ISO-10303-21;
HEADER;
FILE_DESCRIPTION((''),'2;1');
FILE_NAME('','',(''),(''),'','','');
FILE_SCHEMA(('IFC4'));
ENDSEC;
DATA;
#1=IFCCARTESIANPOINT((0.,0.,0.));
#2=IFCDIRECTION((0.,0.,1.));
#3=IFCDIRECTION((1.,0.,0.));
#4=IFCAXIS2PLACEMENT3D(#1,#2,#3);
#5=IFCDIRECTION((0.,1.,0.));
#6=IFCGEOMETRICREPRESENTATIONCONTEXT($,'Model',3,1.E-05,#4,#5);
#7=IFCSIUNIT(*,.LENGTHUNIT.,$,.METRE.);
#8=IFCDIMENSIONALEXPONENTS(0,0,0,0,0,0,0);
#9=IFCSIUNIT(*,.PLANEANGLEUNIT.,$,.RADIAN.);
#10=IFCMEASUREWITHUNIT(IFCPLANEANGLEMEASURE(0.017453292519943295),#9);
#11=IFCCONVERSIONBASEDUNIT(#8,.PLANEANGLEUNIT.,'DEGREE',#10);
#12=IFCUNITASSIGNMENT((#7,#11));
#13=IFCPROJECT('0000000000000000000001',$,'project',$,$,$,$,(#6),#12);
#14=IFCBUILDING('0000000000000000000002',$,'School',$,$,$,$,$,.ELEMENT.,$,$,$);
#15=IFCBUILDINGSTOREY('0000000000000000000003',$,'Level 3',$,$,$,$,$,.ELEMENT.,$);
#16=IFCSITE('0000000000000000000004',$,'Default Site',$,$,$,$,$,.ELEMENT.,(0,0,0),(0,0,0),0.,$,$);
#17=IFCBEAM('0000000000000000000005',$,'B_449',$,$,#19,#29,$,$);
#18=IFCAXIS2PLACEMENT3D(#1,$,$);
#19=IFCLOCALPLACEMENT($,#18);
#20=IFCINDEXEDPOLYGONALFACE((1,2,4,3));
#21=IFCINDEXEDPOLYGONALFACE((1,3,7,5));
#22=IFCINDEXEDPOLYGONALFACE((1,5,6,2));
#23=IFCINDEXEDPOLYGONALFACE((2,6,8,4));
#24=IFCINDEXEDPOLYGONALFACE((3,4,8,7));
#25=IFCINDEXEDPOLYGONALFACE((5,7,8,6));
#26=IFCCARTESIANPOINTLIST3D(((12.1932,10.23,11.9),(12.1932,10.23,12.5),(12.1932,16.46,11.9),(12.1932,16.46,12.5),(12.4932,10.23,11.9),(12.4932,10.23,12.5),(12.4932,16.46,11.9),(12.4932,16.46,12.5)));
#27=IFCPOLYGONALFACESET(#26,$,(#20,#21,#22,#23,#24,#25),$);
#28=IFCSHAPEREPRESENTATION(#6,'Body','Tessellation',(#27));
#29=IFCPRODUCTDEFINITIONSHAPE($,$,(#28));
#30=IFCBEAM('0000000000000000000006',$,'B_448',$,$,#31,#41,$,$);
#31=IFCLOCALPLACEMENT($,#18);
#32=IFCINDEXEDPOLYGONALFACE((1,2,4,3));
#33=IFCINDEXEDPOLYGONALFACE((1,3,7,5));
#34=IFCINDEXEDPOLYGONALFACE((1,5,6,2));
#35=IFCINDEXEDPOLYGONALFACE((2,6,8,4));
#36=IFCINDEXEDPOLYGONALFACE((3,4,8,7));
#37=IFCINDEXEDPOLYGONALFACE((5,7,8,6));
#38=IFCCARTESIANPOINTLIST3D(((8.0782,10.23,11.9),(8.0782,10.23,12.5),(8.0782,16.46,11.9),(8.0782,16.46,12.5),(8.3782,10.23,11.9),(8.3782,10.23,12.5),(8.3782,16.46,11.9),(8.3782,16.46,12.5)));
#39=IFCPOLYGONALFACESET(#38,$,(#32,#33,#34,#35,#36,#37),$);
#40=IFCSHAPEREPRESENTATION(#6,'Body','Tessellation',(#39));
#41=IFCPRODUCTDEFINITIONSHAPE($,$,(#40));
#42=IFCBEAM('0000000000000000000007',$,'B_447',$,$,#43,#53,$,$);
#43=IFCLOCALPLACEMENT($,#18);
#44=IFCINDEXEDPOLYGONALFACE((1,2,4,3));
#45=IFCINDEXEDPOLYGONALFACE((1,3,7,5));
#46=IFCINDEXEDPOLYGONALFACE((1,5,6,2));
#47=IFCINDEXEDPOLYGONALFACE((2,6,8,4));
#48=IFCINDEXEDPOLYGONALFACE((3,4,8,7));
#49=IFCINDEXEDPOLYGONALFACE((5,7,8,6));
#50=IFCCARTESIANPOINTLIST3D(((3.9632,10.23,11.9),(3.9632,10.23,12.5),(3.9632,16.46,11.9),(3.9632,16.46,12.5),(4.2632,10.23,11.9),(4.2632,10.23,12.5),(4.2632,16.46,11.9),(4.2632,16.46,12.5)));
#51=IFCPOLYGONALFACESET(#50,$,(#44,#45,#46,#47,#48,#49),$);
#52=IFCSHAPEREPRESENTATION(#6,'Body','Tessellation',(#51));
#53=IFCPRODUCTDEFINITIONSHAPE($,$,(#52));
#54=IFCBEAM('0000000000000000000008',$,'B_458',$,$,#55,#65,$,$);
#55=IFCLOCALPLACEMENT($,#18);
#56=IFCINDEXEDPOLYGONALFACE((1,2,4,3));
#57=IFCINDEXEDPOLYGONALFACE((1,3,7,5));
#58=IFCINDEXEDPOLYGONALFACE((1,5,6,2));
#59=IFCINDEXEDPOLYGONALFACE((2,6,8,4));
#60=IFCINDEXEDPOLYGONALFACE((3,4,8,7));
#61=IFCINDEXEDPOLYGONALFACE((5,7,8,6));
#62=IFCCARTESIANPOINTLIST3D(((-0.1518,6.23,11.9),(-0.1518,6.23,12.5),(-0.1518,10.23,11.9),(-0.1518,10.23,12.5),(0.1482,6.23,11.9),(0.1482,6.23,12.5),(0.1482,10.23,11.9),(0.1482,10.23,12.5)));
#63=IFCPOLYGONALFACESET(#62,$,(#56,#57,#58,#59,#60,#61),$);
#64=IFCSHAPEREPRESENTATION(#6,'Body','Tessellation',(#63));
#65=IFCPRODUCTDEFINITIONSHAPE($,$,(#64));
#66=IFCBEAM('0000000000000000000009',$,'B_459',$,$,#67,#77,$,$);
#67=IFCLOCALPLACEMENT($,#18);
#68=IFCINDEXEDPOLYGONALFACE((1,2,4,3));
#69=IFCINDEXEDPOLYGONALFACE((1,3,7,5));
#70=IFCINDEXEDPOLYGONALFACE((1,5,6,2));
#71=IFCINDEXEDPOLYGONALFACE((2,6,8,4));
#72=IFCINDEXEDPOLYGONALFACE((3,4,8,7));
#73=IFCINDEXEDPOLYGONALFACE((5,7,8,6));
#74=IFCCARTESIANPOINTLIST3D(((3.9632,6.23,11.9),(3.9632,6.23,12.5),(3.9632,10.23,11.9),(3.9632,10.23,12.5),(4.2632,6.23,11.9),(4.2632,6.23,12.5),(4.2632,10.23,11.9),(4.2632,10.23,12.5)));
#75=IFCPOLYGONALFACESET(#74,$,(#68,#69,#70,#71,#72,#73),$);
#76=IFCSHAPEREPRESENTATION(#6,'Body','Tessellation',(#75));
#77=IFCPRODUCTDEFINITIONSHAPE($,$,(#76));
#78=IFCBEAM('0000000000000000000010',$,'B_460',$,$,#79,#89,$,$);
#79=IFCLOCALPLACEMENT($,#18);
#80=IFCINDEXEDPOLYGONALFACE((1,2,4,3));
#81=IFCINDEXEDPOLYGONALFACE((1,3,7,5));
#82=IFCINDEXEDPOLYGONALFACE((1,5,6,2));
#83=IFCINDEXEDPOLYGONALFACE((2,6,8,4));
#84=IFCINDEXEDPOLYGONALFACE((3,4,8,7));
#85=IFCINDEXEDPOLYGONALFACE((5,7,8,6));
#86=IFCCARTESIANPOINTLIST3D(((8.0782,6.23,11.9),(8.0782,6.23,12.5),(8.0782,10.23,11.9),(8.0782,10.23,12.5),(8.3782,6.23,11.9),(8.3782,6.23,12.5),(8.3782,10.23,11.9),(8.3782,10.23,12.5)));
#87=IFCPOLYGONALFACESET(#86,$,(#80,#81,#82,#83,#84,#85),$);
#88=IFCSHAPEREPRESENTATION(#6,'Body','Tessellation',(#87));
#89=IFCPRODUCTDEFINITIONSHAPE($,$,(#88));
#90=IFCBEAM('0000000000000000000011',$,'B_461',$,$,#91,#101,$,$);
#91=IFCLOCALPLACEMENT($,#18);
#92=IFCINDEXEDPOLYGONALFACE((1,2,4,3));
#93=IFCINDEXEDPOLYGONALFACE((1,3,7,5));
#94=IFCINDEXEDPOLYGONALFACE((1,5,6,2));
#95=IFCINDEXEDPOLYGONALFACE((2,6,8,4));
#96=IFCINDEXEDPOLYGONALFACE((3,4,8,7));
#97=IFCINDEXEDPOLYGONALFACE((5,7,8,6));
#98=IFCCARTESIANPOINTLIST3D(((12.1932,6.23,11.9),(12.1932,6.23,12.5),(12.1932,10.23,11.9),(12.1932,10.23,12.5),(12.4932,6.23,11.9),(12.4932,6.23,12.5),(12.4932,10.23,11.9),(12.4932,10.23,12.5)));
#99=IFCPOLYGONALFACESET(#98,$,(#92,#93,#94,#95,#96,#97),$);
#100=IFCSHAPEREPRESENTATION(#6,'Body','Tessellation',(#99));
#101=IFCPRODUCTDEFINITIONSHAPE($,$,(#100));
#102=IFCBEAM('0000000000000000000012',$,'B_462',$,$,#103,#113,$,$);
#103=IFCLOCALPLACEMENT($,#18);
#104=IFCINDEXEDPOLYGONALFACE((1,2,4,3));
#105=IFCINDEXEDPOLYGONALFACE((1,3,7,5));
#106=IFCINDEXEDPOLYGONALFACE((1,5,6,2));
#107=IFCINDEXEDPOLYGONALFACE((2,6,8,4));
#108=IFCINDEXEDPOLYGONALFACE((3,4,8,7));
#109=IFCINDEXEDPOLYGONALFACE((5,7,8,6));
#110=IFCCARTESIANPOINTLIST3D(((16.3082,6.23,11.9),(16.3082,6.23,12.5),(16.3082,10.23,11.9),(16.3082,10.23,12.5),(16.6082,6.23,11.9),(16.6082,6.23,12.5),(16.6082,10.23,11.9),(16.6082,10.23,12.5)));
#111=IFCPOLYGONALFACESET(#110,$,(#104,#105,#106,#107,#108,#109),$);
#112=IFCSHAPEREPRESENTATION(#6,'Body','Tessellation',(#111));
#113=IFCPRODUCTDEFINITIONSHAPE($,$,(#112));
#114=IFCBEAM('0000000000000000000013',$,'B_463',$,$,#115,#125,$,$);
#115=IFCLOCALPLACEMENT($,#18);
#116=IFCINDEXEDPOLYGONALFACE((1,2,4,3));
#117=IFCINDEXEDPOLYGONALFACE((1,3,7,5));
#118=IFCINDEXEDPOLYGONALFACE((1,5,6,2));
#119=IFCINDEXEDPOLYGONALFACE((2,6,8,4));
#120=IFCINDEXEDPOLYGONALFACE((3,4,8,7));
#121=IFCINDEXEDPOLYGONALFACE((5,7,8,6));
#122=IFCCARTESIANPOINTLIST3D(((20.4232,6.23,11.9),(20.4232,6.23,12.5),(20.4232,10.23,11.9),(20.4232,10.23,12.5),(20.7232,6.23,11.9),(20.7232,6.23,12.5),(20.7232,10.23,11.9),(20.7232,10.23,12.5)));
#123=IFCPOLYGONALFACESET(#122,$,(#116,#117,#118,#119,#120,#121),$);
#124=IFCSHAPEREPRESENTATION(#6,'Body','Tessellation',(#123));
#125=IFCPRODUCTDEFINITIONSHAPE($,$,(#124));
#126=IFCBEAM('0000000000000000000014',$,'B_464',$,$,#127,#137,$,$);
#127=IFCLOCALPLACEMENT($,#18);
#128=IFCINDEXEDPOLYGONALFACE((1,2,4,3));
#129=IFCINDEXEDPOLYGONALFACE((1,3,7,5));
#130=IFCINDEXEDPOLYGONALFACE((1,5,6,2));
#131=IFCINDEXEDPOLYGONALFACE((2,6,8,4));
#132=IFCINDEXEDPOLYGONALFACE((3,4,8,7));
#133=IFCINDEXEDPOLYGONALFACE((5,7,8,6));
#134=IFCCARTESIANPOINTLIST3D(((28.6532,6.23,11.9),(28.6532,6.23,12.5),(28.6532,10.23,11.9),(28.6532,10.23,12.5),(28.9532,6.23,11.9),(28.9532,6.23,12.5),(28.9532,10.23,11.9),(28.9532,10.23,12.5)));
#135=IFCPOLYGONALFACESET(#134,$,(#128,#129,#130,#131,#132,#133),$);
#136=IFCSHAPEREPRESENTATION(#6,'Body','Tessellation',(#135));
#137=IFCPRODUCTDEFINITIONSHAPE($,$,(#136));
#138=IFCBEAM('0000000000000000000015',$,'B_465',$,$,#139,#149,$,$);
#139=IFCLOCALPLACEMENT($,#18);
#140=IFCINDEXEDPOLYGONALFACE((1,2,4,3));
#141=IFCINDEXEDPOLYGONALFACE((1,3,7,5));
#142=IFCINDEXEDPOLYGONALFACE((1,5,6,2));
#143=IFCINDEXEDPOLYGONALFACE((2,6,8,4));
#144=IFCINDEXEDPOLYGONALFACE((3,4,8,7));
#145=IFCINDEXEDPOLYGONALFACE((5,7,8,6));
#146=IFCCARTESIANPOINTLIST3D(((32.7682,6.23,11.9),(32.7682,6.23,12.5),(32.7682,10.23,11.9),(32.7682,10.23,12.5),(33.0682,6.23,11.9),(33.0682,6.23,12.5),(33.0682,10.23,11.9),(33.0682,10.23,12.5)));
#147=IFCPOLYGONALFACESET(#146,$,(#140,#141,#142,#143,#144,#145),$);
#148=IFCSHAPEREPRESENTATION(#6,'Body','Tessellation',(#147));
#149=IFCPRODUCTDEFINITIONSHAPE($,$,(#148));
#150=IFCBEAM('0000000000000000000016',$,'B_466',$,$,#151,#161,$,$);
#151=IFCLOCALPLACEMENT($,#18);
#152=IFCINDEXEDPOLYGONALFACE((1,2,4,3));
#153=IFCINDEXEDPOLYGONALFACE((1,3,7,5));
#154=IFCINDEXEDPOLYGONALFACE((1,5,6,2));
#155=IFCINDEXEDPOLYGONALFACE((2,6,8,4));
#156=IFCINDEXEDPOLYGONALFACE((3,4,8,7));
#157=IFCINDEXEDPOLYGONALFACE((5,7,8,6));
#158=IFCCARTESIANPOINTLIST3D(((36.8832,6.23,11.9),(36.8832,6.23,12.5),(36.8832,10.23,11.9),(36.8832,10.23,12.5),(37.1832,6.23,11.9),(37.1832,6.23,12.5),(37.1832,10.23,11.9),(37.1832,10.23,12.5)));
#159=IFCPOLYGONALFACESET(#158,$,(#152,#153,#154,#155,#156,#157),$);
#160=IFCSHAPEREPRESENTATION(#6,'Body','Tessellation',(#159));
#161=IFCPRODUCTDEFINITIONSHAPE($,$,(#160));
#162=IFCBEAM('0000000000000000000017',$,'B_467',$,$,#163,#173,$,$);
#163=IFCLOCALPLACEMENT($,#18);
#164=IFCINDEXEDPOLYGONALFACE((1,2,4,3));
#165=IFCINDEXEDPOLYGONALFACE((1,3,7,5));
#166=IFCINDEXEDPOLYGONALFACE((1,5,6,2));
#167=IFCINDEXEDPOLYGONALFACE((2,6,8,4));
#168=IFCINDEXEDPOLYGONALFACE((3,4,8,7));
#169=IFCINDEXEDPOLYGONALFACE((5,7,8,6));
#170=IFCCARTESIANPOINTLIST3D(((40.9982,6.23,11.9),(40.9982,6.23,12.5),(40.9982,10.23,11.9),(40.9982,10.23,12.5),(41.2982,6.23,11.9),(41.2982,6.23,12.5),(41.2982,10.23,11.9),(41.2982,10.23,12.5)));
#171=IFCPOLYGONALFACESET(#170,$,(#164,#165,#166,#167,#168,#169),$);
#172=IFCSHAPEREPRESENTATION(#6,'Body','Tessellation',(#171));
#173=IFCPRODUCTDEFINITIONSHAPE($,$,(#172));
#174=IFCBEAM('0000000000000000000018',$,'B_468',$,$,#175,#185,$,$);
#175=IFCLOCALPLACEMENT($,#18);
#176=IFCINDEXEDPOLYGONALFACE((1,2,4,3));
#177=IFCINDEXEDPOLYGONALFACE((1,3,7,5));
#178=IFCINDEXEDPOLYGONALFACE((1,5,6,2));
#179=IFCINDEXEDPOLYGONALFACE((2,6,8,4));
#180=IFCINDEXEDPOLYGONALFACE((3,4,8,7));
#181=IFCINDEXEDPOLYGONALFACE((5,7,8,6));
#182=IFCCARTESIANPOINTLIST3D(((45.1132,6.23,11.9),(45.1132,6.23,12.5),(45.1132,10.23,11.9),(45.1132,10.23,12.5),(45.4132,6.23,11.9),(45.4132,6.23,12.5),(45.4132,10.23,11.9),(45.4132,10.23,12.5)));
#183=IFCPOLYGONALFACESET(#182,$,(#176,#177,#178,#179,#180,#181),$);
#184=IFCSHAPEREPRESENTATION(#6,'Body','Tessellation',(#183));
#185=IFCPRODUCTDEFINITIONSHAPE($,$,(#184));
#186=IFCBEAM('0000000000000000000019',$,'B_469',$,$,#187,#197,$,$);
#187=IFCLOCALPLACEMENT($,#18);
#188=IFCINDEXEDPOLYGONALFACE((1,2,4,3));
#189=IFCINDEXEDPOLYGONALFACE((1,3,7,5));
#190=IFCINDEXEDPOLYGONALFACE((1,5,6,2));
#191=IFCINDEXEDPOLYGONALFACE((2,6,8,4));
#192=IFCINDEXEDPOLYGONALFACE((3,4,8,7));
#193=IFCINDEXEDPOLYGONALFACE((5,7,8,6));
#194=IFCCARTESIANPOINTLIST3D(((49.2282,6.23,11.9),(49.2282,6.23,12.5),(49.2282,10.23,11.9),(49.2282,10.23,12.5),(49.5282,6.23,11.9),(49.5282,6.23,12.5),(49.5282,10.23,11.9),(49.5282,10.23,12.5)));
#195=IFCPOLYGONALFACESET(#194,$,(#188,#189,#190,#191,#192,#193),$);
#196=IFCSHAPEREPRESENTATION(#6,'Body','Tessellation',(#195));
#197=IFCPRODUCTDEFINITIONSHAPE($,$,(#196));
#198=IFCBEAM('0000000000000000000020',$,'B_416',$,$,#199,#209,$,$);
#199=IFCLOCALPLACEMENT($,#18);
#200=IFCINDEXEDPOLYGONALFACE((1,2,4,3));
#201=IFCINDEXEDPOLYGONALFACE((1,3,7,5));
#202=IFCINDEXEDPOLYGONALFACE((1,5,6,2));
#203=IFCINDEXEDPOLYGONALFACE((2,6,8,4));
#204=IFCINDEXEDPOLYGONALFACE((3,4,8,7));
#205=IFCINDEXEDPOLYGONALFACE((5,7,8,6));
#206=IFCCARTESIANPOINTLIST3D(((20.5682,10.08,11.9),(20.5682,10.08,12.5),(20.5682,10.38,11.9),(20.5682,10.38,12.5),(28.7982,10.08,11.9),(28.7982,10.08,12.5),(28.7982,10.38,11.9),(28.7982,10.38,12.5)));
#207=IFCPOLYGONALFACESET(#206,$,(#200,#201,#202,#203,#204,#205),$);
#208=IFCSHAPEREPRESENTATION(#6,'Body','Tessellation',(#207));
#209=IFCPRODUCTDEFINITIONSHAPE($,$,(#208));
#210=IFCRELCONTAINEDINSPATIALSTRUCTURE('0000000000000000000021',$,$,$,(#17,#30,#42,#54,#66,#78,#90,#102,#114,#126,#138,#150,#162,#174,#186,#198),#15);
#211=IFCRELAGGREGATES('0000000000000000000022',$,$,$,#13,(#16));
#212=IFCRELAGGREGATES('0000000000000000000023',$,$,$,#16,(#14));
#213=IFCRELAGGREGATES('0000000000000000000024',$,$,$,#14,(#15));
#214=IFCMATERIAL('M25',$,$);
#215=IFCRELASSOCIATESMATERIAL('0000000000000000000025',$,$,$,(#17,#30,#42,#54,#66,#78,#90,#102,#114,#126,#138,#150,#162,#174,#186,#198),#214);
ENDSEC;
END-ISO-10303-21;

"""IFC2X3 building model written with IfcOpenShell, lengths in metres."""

from ifc_helpers import new_model, entity, si_unit, converted_unit, direction, frame, frame_2d, origin_with_axes, place, context, project, spatial, rectangle, extrude, material, element, save


model = new_model("IFC2X3")

# Units and contexts
model_context = context("Model", 3, precision=1e-05, world=origin_with_axes(), true_north=direction((0.0, 1.0, 0.0)))
ifc_project = project(units=[si_unit("LENGTHUNIT", "METRE"), converted_unit("PLANEANGLEUNIT", "DEGREE", entity("IfcPlaneAngleMeasure", 0.017453292519943295), si_unit("PLANEANGLEUNIT", "RADIAN"), dimensions=[0, 0, 0, 0, 0, 0, 0])], contexts=[model_context])

# Site, building, storey
site = spatial("IfcSite", under=ifc_project, Name="Default Site", CompositionType="ELEMENT", RefLatitude=(0, 0, 0), RefLongitude=(0, 0, 0), RefElevation=0.0)
building = spatial("IfcBuilding", under=site, Name="School", CompositionType="ELEMENT")
storey = spatial("IfcBuildingStorey", under=building, Name="Level 3", CompositionType="ELEMENT")

# Shared definitions
ifc_material = material(Name="M25")
placement = place(None, origin_with_axes())

# Beams
element("IfcBeam", 1, at=placement, inside=storey, material=ifc_material, Name="B_449", context=model_context, shape_type="SweptSolid", body=[
    extrude(rectangle(XDim=0.3, YDim=0.6, at=frame_2d((0.0, 0.0), x_axis=(0.0, 1.0, 0.0))), frame((12.3432, 10.23, 12.2), z_axis=(0.0, 1.0, 0.0), x_axis=(0.0, 0.0, -1.0)), (0.0, 0.0, 1.0), 6.23),
])
element("IfcBeam", 2, at=placement, inside=storey, material=ifc_material, Name="B_448", context=model_context, shape_type="SweptSolid", body=[
    extrude(rectangle(XDim=0.3, YDim=0.6, at=frame_2d((0.0, 0.0), x_axis=(0.0, 1.0, 0.0))), frame((8.2282, 10.23, 12.2), z_axis=(0.0, 1.0, 0.0), x_axis=(0.0, 0.0, -1.0)), (0.0, 0.0, 1.0), 6.23),
])
element("IfcBeam", 3, at=placement, inside=storey, material=ifc_material, Name="B_447", context=model_context, shape_type="SweptSolid", body=[
    extrude(rectangle(XDim=0.3, YDim=0.6, at=frame_2d((0.0, 0.0), x_axis=(0.0, 1.0, 0.0))), frame((4.1132, 10.23, 12.2), z_axis=(0.0, 1.0, 0.0), x_axis=(0.0, 0.0, -1.0)), (0.0, 0.0, 1.0), 6.23),
])
element("IfcBeam", 4, at=placement, inside=storey, material=ifc_material, Name="B_458", context=model_context, shape_type="SweptSolid", body=[
    extrude(rectangle(XDim=0.3, YDim=0.6, at=frame_2d((0.0, 0.0), x_axis=(0.0, 1.0, 0.0))), frame((-0.0018, 6.23, 12.2), z_axis=(0.0, 1.0, 0.0), x_axis=(0.0, 0.0, -1.0)), (0.0, 0.0, 1.0), 4.0),
])
element("IfcBeam", 5, at=placement, inside=storey, material=ifc_material, Name="B_459", context=model_context, shape_type="SweptSolid", body=[
    extrude(rectangle(XDim=0.3, YDim=0.6, at=frame_2d((0.0, 0.0), x_axis=(0.0, 1.0, 0.0))), frame((4.1132, 6.23, 12.2), z_axis=(0.0, 1.0, 0.0), x_axis=(0.0, 0.0, -1.0)), (0.0, 0.0, 1.0), 4.0),
])
element("IfcBeam", 6, at=placement, inside=storey, material=ifc_material, Name="B_460", context=model_context, shape_type="SweptSolid", body=[
    extrude(rectangle(XDim=0.3, YDim=0.6, at=frame_2d((0.0, 0.0), x_axis=(0.0, 1.0, 0.0))), frame((8.2282, 6.23, 12.2), z_axis=(0.0, 1.0, 0.0), x_axis=(0.0, 0.0, -1.0)), (0.0, 0.0, 1.0), 4.0),
])
element("IfcBeam", 7, at=placement, inside=storey, material=ifc_material, Name="B_461", context=model_context, shape_type="SweptSolid", body=[
    extrude(rectangle(XDim=0.3, YDim=0.6, at=frame_2d((0.0, 0.0), x_axis=(0.0, 1.0, 0.0))), frame((12.3432, 6.23, 12.2), z_axis=(0.0, 1.0, 0.0), x_axis=(0.0, 0.0, -1.0)), (0.0, 0.0, 1.0), 4.0),
])
element("IfcBeam", 8, at=placement, inside=storey, material=ifc_material, Name="B_462", context=model_context, shape_type="SweptSolid", body=[
    extrude(rectangle(XDim=0.3, YDim=0.6, at=frame_2d((0.0, 0.0), x_axis=(0.0, 1.0, 0.0))), frame((16.4582, 6.23, 12.2), z_axis=(0.0, 1.0, 0.0), x_axis=(0.0, 0.0, -1.0)), (0.0, 0.0, 1.0), 4.0),
])
element("IfcBeam", 9, at=placement, inside=storey, material=ifc_material, Name="B_463", context=model_context, shape_type="SweptSolid", body=[
    extrude(rectangle(XDim=0.3, YDim=0.6, at=frame_2d((0.0, 0.0), x_axis=(0.0, 1.0, 0.0))), frame((20.5732, 6.23, 12.2), z_axis=(0.0, 1.0, 0.0), x_axis=(0.0, 0.0, -1.0)), (0.0, 0.0, 1.0), 4.0),
])
element("IfcBeam", 10, at=placement, inside=storey, material=ifc_material, Name="B_464", context=model_context, shape_type="SweptSolid", body=[
    extrude(rectangle(XDim=0.3, YDim=0.6, at=frame_2d((0.0, 0.0), x_axis=(0.0, 1.0, 0.0))), frame((28.8032, 6.23, 12.2), z_axis=(0.0, 1.0, 0.0), x_axis=(0.0, 0.0, -1.0)), (0.0, 0.0, 1.0), 4.0),
])
element("IfcBeam", 11, at=placement, inside=storey, material=ifc_material, Name="B_465", context=model_context, shape_type="SweptSolid", body=[
    extrude(rectangle(XDim=0.3, YDim=0.6, at=frame_2d((0.0, 0.0), x_axis=(0.0, 1.0, 0.0))), frame((32.9182, 6.23, 12.2), z_axis=(0.0, 1.0, 0.0), x_axis=(0.0, 0.0, -1.0)), (0.0, 0.0, 1.0), 4.0),
])
element("IfcBeam", 12, at=placement, inside=storey, material=ifc_material, Name="B_466", context=model_context, shape_type="SweptSolid", body=[
    extrude(rectangle(XDim=0.3, YDim=0.6, at=frame_2d((0.0, 0.0), x_axis=(0.0, 1.0, 0.0))), frame((37.0332, 6.23, 12.2), z_axis=(0.0, 1.0, 0.0), x_axis=(0.0, 0.0, -1.0)), (0.0, 0.0, 1.0), 4.0),
])
element("IfcBeam", 13, at=placement, inside=storey, material=ifc_material, Name="B_467", context=model_context, shape_type="SweptSolid", body=[
    extrude(rectangle(XDim=0.3, YDim=0.6, at=frame_2d((0.0, 0.0), x_axis=(0.0, 1.0, 0.0))), frame((41.1482, 6.23, 12.2), z_axis=(0.0, 1.0, 0.0), x_axis=(0.0, 0.0, -1.0)), (0.0, 0.0, 1.0), 4.0),
])
element("IfcBeam", 14, at=placement, inside=storey, material=ifc_material, Name="B_468", context=model_context, shape_type="SweptSolid", body=[
    extrude(rectangle(XDim=0.3, YDim=0.6, at=frame_2d((0.0, 0.0), x_axis=(0.0, 1.0, 0.0))), frame((45.2632, 6.23, 12.2), z_axis=(0.0, 1.0, 0.0), x_axis=(0.0, 0.0, -1.0)), (0.0, 0.0, 1.0), 4.0),
])
element("IfcBeam", 15, at=placement, inside=storey, material=ifc_material, Name="B_469", context=model_context, shape_type="SweptSolid", body=[
    extrude(rectangle(XDim=0.3, YDim=0.6, at=frame_2d((0.0, 0.0), x_axis=(0.0, 1.0, 0.0))), frame((49.3782, 6.23, 12.2), z_axis=(0.0, 1.0, 0.0), x_axis=(0.0, 0.0, -1.0)), (0.0, 0.0, 1.0), 4.0),
])
element("IfcBeam", 16, at=placement, inside=storey, material=ifc_material, Name="B_416", context=model_context, shape_type="SweptSolid", body=[
    extrude(rectangle(XDim=0.3, YDim=0.6, at=frame_2d((0.0, 0.0), x_axis=(0.0, 1.0, 0.0))), frame((20.5682, 10.23, 12.2), z_axis=(1.0, 0.0, 0.0), x_axis=(0.0, 0.0, -1.0)), (0.0, 0.0, 1.0), 8.23),
])

save(model, "model.ifc")
